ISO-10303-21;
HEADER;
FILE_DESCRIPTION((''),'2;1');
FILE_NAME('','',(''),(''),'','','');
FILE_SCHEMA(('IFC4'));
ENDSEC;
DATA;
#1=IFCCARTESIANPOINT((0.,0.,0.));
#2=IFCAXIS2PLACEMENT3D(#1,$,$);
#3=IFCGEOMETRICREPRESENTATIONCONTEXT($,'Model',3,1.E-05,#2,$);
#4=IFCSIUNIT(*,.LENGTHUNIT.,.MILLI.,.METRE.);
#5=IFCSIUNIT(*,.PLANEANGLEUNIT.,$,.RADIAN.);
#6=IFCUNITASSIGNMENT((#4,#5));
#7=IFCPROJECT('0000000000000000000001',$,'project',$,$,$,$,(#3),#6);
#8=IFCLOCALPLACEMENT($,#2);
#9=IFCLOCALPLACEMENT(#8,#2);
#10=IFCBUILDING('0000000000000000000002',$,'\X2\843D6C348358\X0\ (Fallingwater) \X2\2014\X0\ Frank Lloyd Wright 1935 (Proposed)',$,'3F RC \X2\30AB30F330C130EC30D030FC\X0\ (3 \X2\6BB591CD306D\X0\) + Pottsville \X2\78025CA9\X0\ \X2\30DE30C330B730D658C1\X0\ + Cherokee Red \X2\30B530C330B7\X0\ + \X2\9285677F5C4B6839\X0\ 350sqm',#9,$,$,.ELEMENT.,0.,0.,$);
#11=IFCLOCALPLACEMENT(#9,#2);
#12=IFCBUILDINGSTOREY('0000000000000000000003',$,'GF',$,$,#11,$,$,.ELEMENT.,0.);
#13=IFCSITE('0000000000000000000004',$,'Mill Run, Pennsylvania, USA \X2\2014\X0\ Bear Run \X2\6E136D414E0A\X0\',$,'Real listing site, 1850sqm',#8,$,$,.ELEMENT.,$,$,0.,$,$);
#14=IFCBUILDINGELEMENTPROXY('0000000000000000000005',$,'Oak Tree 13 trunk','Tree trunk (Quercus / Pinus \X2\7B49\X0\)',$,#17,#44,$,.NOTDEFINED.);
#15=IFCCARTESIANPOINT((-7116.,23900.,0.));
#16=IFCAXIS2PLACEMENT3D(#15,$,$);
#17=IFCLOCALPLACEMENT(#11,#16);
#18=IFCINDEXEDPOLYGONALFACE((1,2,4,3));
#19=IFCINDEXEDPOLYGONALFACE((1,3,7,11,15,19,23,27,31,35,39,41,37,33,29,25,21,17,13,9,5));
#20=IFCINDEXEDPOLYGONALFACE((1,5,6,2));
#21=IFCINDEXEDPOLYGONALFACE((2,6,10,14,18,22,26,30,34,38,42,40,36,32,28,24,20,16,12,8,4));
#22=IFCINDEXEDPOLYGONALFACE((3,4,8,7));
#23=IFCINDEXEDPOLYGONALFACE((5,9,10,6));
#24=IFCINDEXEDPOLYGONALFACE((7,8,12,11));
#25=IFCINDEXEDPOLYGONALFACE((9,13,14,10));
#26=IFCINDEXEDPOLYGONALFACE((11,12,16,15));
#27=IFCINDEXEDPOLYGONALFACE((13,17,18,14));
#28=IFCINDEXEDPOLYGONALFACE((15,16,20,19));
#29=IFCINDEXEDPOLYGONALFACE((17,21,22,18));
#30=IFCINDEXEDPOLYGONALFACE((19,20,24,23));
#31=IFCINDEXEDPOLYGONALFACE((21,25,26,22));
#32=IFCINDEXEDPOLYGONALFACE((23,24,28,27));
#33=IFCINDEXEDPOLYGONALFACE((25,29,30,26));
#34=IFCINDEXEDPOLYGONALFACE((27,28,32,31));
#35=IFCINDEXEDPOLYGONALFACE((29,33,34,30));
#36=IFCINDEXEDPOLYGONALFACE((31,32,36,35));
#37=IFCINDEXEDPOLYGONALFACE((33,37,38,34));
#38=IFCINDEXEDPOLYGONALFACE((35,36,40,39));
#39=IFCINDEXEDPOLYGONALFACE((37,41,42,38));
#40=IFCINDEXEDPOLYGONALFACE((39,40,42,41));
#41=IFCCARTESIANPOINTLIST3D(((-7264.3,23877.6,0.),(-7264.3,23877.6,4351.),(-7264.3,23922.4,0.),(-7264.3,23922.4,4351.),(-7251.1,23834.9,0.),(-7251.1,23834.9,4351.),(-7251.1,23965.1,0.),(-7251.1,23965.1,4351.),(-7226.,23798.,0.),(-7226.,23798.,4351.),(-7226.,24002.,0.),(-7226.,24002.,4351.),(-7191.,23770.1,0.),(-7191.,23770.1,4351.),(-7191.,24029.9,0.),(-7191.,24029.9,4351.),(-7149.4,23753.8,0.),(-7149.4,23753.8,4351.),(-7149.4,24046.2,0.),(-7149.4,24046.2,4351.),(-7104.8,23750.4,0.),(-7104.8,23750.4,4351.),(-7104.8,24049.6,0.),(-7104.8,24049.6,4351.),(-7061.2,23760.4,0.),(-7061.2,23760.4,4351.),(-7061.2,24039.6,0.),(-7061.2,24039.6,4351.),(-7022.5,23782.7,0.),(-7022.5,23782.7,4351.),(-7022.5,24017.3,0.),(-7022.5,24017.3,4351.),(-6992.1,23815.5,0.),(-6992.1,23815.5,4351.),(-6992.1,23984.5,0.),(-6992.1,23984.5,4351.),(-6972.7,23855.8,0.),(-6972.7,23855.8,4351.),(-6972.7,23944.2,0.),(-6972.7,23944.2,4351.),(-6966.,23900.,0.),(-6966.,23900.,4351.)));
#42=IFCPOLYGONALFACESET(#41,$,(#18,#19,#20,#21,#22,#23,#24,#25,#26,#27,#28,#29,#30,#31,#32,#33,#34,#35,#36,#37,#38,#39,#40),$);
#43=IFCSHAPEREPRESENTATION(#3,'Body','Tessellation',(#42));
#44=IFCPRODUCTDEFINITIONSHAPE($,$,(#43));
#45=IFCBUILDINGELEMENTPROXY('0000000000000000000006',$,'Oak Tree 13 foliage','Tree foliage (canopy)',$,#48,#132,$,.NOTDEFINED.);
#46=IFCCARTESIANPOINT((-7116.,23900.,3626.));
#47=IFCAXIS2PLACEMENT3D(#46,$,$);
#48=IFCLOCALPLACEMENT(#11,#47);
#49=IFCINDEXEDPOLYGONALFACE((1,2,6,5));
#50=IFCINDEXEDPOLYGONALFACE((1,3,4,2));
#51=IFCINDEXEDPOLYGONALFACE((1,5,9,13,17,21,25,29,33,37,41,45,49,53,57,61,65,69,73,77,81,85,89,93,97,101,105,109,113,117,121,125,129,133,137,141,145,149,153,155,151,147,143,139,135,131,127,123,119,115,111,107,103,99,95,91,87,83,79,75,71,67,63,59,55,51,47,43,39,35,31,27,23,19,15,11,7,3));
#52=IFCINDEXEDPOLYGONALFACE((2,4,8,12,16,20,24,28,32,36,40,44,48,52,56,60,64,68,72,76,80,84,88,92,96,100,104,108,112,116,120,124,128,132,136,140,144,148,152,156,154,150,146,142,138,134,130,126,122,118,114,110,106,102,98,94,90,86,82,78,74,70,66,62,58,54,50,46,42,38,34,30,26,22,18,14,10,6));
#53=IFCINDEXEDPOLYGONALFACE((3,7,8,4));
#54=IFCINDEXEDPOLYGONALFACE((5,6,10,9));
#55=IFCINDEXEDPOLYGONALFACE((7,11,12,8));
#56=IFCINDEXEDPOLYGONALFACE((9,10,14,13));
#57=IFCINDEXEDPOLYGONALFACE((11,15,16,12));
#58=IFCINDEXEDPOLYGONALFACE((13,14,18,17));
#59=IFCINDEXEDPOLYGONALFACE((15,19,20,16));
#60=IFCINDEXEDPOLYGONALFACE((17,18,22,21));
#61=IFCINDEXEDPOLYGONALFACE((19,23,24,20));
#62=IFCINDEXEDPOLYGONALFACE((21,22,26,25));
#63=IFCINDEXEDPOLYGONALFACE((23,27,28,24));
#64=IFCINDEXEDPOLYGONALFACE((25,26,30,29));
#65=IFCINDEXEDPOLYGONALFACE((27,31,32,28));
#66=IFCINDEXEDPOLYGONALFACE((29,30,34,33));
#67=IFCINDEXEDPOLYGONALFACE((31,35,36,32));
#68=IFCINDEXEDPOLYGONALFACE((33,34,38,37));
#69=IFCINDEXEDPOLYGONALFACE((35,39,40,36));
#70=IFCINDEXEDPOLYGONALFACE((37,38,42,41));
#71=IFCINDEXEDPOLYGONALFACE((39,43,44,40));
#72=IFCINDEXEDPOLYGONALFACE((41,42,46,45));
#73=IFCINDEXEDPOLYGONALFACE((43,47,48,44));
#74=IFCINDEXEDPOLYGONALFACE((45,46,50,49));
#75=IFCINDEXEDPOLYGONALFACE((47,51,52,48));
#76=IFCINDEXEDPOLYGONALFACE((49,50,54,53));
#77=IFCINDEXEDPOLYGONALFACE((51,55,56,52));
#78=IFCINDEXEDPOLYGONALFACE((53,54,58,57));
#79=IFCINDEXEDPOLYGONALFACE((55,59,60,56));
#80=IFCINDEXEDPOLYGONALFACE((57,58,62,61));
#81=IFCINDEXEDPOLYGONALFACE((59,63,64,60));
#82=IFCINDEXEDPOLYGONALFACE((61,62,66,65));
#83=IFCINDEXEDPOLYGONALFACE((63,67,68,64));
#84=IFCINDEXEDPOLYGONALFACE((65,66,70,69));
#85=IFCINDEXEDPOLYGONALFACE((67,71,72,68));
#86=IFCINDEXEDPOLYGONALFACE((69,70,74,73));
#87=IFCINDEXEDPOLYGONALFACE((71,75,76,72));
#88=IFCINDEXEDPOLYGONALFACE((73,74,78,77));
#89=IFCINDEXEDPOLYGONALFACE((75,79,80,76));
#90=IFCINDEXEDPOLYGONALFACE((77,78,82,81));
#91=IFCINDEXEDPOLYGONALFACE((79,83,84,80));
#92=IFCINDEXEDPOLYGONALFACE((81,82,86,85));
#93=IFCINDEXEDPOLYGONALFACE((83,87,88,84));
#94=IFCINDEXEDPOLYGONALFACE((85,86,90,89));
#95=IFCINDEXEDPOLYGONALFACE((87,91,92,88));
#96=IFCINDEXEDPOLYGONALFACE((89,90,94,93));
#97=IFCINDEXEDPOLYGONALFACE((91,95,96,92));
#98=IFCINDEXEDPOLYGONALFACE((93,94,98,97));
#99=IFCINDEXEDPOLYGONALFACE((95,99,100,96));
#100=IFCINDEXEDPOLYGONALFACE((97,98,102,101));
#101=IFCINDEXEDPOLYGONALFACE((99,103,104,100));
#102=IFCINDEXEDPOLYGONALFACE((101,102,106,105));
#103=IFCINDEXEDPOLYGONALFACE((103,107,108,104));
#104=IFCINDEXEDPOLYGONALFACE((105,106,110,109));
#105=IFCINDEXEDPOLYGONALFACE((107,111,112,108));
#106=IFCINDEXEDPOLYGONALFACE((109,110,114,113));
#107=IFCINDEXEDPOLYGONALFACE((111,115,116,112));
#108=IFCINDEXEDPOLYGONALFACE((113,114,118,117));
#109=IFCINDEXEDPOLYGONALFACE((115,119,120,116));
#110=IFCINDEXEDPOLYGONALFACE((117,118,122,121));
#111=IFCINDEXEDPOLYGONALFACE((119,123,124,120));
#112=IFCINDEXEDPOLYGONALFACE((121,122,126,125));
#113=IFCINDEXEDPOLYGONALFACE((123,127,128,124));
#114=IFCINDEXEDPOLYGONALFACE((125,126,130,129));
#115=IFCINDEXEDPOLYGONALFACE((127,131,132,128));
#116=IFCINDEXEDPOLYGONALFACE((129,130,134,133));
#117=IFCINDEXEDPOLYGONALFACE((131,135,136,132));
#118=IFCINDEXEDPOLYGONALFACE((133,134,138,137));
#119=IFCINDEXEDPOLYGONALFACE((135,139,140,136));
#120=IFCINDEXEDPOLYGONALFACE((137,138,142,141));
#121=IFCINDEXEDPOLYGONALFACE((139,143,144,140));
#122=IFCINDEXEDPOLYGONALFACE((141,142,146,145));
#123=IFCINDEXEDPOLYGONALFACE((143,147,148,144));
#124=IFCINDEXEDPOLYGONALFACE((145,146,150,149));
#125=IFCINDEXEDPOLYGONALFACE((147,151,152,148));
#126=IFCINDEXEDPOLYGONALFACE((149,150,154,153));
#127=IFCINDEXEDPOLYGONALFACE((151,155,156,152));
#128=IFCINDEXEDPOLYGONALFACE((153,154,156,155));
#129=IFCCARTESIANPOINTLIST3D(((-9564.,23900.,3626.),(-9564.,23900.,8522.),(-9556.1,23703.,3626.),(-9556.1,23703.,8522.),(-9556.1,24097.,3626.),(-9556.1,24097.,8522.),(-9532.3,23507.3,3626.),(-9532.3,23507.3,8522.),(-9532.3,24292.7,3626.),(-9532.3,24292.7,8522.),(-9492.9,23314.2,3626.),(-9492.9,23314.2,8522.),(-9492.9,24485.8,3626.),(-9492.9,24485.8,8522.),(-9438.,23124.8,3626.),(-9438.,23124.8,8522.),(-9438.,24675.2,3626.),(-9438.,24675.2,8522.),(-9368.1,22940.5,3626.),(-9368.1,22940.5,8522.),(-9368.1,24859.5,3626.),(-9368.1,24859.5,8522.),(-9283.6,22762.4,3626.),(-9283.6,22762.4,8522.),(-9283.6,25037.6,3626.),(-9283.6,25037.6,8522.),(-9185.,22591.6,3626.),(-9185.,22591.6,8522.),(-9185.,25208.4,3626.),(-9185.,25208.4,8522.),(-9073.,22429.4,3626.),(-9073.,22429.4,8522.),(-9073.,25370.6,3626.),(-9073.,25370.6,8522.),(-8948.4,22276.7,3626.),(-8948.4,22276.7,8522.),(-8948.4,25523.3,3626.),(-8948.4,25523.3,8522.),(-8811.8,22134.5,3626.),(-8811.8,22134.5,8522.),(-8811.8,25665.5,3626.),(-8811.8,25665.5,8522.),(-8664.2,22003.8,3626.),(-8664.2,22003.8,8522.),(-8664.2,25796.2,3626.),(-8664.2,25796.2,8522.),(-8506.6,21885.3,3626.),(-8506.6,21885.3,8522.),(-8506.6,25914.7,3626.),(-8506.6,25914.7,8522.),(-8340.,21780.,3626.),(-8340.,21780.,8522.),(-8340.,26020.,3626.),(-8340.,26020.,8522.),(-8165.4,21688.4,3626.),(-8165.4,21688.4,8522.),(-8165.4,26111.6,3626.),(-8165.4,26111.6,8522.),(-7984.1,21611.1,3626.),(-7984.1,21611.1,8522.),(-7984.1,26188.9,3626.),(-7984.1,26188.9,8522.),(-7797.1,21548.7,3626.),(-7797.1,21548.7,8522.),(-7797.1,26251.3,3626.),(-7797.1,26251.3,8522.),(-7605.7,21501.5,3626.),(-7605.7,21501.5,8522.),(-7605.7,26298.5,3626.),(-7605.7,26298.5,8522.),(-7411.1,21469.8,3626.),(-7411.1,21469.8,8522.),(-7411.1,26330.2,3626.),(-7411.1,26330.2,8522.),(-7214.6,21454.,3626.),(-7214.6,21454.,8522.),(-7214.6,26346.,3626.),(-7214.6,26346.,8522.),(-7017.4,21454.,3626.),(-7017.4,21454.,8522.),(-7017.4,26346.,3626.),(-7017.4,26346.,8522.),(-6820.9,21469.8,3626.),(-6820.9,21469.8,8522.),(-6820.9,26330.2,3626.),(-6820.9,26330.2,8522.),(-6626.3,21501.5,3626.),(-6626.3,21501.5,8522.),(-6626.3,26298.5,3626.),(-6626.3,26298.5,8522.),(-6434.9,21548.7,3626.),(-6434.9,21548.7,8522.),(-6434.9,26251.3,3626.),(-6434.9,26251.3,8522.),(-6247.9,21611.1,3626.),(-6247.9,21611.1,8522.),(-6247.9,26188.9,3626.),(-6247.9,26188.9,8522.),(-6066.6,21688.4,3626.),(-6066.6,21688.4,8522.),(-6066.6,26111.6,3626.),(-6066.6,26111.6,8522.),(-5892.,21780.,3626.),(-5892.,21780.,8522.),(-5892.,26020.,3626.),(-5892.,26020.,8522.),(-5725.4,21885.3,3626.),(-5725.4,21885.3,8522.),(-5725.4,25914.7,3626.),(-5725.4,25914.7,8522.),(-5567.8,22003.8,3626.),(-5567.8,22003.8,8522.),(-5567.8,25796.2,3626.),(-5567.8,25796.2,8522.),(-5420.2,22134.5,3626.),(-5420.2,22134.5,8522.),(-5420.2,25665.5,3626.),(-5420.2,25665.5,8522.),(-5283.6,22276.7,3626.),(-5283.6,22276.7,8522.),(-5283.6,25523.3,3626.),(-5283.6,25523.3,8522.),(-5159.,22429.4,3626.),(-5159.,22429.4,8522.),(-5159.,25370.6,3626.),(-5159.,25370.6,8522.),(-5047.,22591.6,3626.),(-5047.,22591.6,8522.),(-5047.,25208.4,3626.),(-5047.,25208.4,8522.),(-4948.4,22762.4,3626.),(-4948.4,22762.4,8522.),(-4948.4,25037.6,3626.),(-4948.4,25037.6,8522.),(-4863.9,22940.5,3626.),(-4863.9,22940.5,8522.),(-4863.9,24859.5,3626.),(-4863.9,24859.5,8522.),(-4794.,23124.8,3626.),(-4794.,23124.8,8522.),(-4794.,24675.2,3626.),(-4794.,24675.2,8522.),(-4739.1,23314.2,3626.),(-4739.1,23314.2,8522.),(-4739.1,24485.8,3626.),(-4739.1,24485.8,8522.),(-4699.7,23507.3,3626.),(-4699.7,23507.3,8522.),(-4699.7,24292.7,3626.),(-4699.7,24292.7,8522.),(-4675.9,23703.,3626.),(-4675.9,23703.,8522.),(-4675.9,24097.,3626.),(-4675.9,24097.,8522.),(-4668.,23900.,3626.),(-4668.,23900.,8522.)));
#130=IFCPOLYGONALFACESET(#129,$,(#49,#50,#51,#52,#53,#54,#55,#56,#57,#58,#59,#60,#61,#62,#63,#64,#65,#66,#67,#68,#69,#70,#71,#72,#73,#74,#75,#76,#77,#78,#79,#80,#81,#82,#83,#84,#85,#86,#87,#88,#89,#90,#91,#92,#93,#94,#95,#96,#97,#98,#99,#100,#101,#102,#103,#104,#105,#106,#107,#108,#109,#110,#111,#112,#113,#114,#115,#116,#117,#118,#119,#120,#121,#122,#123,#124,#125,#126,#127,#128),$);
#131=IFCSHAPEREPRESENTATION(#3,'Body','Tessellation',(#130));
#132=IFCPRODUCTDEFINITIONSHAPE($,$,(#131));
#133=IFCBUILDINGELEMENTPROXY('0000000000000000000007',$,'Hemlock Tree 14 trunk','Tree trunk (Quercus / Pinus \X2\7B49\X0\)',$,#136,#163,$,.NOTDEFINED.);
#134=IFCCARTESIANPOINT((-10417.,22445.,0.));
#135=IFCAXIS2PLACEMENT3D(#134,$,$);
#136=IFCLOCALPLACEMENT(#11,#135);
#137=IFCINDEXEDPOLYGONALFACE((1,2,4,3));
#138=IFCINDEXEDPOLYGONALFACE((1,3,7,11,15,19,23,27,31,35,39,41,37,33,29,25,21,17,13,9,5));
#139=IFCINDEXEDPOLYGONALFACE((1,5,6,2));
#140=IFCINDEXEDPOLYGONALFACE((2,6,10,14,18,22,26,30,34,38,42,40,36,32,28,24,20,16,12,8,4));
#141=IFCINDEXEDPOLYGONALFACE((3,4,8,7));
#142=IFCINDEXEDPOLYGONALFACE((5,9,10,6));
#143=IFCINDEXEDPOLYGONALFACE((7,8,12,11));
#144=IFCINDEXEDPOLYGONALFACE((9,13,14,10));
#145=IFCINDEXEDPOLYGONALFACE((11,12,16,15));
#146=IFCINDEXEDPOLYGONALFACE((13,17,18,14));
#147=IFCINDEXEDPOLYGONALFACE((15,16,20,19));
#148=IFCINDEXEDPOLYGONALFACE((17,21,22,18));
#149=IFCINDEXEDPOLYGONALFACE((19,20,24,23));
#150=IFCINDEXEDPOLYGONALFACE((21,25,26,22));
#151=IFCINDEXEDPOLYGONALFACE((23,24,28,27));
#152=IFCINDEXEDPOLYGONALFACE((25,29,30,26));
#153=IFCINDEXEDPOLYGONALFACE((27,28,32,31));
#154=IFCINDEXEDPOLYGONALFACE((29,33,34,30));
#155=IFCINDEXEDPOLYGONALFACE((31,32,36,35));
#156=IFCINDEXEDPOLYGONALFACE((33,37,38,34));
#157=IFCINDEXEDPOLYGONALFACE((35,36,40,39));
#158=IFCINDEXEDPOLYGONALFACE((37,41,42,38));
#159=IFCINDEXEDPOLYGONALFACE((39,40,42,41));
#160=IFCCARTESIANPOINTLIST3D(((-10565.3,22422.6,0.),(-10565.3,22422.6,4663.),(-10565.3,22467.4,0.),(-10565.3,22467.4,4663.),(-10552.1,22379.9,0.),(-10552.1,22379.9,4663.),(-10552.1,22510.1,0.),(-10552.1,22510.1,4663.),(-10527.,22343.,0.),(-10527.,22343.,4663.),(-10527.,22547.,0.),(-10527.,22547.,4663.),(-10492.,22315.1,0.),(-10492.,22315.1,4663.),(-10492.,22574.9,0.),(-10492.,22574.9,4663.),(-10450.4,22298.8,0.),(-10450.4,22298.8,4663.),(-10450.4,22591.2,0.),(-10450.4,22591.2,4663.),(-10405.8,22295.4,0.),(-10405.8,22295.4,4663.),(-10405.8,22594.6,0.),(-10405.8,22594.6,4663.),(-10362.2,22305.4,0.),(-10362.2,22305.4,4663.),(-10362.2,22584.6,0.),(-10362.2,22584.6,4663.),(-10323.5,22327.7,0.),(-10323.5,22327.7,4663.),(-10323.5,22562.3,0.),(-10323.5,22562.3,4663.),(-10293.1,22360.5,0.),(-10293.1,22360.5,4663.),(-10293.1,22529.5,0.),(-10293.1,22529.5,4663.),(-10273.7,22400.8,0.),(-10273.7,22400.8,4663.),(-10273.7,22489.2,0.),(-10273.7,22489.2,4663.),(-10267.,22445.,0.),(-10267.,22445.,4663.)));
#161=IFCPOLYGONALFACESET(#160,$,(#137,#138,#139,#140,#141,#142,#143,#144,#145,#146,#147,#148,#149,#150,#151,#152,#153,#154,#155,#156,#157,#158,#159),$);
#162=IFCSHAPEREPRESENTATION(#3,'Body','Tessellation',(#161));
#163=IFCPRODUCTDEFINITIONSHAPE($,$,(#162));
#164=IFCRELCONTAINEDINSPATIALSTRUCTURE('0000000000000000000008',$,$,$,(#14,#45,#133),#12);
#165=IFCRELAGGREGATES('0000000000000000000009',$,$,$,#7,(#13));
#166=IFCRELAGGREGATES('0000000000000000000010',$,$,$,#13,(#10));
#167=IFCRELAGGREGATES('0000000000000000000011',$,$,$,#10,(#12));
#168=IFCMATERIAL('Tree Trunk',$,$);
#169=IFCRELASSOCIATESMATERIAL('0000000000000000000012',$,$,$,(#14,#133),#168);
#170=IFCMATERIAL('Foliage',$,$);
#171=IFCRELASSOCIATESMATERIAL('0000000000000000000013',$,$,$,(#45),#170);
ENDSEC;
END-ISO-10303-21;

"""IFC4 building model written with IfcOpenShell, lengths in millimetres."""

from ifc_helpers import new_model, si_unit, frame, origin, origin_2d, place, context, project, spatial, circle, extrude, material, element, save


model = new_model("IFC4")

# Units and contexts
model_context = context("Model", 3, precision=1e-05, world=origin())
ifc_project = project(units=[si_unit("LENGTHUNIT", "METRE", prefix="MILLI"), si_unit("PLANEANGLEUNIT", "RADIAN")], contexts=[model_context])

# Site, building, storey
site_placement = place(None, origin())
site = spatial("IfcSite", under=ifc_project, at=site_placement, Name="Mill Run, Pennsylvania, USA — Bear Run 渓流上", ObjectType="Real listing site, 1850sqm", CompositionType="ELEMENT", RefElevation=0.0)
building_placement = place(site_placement, origin())
building = spatial("IfcBuilding", under=site, at=building_placement, Name="落水荘 (Fallingwater) — Frank Lloyd Wright 1935 (Proposed)", ObjectType="3F RC カンチレバー (3 段重ね) + Pottsville 砂岩 マッシブ壁 + Cherokee Red サッシ + 銅板屋根 350sqm", CompositionType="ELEMENT", ElevationOfRefHeight=0.0, ElevationOfTerrain=0.0)
storey_placement = place(building_placement, origin())
storey = spatial("IfcBuildingStorey", under=building, at=storey_placement, Name="GF", CompositionType="ELEMENT", Elevation=0.0)

# Building element proxies
ifc_material_1 = material(Name="Tree Trunk")
ifc_material_2 = material(Name="Foliage")
proxy_1_placement = place(storey_placement, frame((-7116.0, 23900.0, 0.0)))
element("IfcBuildingElementProxy", 1, at=proxy_1_placement, inside=storey, material=ifc_material_1, Name="Oak Tree 13 trunk", Description="Tree trunk (Quercus / Pinus 等)", PredefinedType="NOTDEFINED", context=model_context, shape_type="SweptSolid", body=[
    extrude(circle(Radius=150.0, at=origin_2d()), frame((-7116.0, 23900.0, 0.0)), (0.0, 0.0, 1.0), 4351.0),
])
proxy_2_placement = place(storey_placement, frame((-7116.0, 23900.0, 3626.0)))
element("IfcBuildingElementProxy", 2, at=proxy_2_placement, inside=storey, material=ifc_material_2, Name="Oak Tree 13 foliage", Description="Tree foliage (canopy)", PredefinedType="NOTDEFINED", context=model_context, shape_type="SweptSolid", body=[
    extrude(circle(Radius=2448.0, at=origin_2d()), frame((-7116.0, 23900.0, 3626.0)), (0.0, 0.0, 1.0), 4896.0),
])
proxy_3_placement = place(storey_placement, frame((-10417.0, 22445.0, 0.0)))
element("IfcBuildingElementProxy", 3, at=proxy_3_placement, inside=storey, material=ifc_material_1, Name="Hemlock Tree 14 trunk", Description="Tree trunk (Quercus / Pinus 等)", PredefinedType="NOTDEFINED", context=model_context, shape_type="SweptSolid", body=[
    extrude(circle(Radius=150.0, at=origin_2d()), frame((-10417.0, 22445.0, 0.0)), (0.0, 0.0, 1.0), 4663.0),
])

save(model, "model.ifc")
